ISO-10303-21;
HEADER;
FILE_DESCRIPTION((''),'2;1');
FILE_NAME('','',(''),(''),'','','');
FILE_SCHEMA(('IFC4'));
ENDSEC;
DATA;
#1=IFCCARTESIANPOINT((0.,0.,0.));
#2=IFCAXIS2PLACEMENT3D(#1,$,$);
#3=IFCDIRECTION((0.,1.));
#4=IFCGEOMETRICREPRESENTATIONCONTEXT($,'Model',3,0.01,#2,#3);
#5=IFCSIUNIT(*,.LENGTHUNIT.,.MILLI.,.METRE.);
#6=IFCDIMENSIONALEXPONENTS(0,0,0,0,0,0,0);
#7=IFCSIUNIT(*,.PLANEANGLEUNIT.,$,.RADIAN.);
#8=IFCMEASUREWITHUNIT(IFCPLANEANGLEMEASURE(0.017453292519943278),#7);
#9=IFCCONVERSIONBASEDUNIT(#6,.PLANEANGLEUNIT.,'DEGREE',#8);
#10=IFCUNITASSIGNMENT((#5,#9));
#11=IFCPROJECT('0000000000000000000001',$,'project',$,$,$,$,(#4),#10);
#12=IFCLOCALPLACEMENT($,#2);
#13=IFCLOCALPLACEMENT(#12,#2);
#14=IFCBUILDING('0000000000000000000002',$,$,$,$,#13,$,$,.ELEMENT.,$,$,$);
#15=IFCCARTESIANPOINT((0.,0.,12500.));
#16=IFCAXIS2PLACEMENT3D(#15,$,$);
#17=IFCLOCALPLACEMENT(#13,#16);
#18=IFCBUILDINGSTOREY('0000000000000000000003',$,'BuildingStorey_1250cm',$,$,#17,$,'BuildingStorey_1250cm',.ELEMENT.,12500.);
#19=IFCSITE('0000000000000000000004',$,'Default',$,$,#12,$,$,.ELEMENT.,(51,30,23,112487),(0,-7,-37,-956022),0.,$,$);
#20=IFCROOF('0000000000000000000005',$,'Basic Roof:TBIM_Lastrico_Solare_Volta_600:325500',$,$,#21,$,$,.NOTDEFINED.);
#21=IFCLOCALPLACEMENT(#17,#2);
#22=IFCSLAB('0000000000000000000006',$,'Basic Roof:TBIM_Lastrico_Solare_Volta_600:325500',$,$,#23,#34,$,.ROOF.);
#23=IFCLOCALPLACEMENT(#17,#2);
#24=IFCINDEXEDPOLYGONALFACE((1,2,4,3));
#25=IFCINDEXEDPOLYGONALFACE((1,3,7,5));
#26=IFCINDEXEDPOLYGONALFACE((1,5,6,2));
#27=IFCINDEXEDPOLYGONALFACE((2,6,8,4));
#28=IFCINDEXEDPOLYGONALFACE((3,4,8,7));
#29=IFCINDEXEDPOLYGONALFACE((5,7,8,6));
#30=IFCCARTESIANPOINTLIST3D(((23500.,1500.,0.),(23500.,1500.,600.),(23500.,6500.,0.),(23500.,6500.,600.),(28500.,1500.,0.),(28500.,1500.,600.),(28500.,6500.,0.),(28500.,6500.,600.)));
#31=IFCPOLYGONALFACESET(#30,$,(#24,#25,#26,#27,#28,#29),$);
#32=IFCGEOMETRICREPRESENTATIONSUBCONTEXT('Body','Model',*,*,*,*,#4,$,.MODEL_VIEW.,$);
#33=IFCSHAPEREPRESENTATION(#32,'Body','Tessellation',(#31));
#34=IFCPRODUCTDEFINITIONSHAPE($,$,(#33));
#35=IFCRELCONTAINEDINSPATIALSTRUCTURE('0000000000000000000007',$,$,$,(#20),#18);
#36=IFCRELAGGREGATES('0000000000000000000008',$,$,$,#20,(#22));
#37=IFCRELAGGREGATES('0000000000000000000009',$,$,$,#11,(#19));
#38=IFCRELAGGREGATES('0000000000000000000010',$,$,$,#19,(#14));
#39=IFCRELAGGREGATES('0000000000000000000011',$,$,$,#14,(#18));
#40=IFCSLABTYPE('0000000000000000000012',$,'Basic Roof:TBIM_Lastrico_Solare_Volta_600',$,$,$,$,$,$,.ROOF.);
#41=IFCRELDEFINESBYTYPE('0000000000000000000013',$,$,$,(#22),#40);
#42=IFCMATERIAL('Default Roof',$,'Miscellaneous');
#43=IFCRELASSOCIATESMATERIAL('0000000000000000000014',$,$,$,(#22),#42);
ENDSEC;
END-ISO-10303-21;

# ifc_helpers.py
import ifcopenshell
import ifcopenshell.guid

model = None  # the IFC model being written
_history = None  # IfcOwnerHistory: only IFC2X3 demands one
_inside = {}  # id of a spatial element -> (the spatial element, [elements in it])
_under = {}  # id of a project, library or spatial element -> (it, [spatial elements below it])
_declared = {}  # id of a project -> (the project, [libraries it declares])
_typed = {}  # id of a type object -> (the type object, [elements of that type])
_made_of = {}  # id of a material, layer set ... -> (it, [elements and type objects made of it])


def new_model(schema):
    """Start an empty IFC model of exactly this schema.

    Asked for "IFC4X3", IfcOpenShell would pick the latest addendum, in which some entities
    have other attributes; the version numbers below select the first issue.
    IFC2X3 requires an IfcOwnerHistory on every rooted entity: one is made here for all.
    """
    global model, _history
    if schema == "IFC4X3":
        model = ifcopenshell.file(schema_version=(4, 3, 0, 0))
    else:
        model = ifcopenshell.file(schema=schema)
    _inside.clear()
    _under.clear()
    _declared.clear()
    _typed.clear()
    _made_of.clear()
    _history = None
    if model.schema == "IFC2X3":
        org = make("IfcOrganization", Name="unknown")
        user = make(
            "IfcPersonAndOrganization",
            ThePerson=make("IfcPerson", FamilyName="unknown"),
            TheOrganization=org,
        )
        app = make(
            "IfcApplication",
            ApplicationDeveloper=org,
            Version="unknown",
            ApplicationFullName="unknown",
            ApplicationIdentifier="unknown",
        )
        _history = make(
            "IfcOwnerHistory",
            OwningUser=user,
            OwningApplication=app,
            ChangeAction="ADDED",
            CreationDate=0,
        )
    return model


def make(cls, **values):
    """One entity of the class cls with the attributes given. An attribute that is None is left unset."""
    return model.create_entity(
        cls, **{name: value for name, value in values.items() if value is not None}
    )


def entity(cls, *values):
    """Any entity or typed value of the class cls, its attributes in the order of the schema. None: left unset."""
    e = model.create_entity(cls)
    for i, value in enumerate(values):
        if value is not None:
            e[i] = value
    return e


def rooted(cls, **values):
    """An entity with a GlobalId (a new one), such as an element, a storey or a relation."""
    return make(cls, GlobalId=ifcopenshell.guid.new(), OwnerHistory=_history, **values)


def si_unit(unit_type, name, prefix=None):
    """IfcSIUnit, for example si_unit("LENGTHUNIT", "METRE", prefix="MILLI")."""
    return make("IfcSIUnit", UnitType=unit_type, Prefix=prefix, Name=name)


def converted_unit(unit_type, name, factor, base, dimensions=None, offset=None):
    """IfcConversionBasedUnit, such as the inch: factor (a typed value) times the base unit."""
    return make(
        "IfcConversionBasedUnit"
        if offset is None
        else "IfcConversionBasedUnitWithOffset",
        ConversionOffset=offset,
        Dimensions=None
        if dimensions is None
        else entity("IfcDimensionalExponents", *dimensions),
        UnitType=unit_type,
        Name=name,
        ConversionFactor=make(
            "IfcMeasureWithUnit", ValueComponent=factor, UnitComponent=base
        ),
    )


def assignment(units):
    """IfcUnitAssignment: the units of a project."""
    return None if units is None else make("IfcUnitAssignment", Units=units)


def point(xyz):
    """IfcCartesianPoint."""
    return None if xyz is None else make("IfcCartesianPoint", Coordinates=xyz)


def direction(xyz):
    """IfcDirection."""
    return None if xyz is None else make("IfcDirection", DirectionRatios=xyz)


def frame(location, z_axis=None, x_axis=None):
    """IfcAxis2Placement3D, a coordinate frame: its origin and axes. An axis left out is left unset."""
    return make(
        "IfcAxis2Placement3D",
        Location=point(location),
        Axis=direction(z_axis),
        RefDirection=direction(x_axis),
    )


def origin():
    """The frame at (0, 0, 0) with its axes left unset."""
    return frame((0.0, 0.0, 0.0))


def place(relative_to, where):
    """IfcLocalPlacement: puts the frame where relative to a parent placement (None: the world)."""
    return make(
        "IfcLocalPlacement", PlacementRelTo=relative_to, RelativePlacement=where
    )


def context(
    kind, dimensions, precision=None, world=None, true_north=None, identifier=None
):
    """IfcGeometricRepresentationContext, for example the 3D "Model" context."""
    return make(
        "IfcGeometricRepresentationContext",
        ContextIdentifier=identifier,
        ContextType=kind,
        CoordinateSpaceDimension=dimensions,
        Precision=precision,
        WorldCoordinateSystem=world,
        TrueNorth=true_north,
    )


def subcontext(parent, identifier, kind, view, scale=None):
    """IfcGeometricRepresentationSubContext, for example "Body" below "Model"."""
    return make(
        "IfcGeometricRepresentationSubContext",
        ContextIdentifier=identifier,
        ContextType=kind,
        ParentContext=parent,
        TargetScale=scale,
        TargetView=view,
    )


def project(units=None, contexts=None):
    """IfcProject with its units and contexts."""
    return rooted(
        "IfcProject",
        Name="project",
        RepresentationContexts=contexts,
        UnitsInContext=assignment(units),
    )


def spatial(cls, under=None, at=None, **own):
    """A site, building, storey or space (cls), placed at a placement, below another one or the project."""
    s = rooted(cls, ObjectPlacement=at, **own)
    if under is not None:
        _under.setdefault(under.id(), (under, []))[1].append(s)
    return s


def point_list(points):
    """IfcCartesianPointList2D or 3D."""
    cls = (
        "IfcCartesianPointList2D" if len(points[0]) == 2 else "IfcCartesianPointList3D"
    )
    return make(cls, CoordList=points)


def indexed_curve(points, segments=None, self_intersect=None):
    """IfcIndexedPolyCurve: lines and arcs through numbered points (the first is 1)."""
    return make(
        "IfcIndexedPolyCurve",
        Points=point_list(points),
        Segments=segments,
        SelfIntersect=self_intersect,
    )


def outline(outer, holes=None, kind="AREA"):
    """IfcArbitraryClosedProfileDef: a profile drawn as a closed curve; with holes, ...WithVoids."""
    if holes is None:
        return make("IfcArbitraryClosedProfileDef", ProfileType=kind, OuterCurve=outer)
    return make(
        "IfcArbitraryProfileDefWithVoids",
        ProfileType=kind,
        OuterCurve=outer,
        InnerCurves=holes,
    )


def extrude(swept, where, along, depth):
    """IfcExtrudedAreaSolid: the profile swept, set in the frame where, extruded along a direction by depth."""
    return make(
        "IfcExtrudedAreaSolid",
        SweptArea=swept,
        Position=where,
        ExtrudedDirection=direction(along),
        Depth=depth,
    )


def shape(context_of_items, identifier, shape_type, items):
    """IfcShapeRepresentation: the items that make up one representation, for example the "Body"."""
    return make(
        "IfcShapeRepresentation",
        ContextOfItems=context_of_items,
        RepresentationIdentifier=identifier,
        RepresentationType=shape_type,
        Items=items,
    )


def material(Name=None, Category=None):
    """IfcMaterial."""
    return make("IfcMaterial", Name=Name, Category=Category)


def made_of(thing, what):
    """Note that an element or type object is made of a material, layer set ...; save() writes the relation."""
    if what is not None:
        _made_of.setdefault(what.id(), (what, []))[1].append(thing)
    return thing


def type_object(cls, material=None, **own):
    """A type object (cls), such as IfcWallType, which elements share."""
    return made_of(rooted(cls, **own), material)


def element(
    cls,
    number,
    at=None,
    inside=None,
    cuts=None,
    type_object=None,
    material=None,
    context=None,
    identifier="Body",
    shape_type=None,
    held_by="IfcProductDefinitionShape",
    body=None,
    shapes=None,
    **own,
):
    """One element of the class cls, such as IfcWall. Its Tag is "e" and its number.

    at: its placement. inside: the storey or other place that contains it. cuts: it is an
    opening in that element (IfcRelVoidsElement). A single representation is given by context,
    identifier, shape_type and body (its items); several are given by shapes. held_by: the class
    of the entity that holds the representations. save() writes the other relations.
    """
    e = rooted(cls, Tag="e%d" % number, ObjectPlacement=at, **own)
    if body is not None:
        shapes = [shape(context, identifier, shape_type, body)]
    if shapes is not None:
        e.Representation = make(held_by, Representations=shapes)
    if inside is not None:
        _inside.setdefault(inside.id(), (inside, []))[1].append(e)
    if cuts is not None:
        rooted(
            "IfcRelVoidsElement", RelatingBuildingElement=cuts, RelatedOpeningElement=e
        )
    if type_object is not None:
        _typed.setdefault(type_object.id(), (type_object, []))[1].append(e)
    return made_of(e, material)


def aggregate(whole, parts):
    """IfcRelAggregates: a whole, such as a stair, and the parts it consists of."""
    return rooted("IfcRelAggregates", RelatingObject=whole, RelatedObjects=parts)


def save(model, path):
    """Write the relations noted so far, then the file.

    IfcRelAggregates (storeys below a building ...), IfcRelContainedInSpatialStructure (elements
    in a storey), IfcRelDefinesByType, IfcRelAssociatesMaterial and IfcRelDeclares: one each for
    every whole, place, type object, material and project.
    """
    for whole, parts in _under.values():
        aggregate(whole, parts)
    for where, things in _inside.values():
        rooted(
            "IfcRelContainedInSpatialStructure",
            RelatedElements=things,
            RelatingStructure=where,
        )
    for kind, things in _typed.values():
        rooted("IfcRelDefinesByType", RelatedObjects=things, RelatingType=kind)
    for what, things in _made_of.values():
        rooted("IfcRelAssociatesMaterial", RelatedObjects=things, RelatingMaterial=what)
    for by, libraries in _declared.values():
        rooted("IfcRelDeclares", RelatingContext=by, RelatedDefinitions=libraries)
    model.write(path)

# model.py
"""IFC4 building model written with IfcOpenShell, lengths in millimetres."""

from ifc_helpers import new_model, entity, si_unit, converted_unit, direction, frame, origin, place, context, subcontext, project, spatial, indexed_curve, outline, extrude, material, type_object, element, aggregate, save


model = new_model("IFC4")

# Units and contexts
model_context = context("Model", 3, precision=0.01, world=origin(), true_north=direction((0.0, 1.0)))
body_context = subcontext(model_context, "Body", "Model", "MODEL_VIEW")
ifc_project = project(units=[si_unit("LENGTHUNIT", "METRE", prefix="MILLI"), converted_unit("PLANEANGLEUNIT", "DEGREE", entity("IfcPlaneAngleMeasure", 0.017453292519943278), si_unit("PLANEANGLEUNIT", "RADIAN"), dimensions=[0, 0, 0, 0, 0, 0, 0])], contexts=[model_context])

# Site, building, storey
site_placement = place(None, origin())
site = spatial("IfcSite", under=ifc_project, at=site_placement, Name="Default", CompositionType="ELEMENT", RefLatitude=(51, 30, 23, 112487), RefLongitude=(0, -7, -37, -956022), RefElevation=0.0)
building_placement = place(site_placement, origin())
building = spatial("IfcBuilding", under=site, at=building_placement, CompositionType="ELEMENT")
storey_placement = place(building_placement, frame((0.0, 0.0, 12500.0)))
storey = spatial("IfcBuildingStorey", under=building, at=storey_placement, Name="BuildingStorey_1250cm", LongName="BuildingStorey_1250cm", CompositionType="ELEMENT", Elevation=12500.0)

# Roof, slab
roof_placement = place(storey_placement, frame((23500.0, 1500.0, 0.0)))
roof = element("IfcRoof", 1, at=roof_placement, inside=storey, Name="Basic Roof:TBIM_Lastrico_Solare_Volta_600:325500", PredefinedType="NOTDEFINED")
ifc_material = material(Name="Default Roof", Category="Miscellaneous")
slab_type = type_object("IfcSlabType", Name="Basic Roof:TBIM_Lastrico_Solare_Volta_600", PredefinedType="ROOF")
slab_placement = place(roof_placement, origin())
slab = element("IfcSlab", 2, at=slab_placement, type_object=slab_type, material=ifc_material, Name="Basic Roof:TBIM_Lastrico_Solare_Volta_600:325500", PredefinedType="ROOF", context=body_context, shape_type="SweptSolid", body=[
    extrude(outline(indexed_curve([(-2500.0, 2500.0), (-2500.0, -2500.0), (2500.0, -2500.0), (2500.0, 2500.0), (-2500.0, 2500.0)], self_intersect=False)), frame((2500.0, 2500.0, 0.0)), (0.0, 0.0, 1.0), 600.0),
])
aggregate(roof, [slab])

save(model, "model.ifc")
